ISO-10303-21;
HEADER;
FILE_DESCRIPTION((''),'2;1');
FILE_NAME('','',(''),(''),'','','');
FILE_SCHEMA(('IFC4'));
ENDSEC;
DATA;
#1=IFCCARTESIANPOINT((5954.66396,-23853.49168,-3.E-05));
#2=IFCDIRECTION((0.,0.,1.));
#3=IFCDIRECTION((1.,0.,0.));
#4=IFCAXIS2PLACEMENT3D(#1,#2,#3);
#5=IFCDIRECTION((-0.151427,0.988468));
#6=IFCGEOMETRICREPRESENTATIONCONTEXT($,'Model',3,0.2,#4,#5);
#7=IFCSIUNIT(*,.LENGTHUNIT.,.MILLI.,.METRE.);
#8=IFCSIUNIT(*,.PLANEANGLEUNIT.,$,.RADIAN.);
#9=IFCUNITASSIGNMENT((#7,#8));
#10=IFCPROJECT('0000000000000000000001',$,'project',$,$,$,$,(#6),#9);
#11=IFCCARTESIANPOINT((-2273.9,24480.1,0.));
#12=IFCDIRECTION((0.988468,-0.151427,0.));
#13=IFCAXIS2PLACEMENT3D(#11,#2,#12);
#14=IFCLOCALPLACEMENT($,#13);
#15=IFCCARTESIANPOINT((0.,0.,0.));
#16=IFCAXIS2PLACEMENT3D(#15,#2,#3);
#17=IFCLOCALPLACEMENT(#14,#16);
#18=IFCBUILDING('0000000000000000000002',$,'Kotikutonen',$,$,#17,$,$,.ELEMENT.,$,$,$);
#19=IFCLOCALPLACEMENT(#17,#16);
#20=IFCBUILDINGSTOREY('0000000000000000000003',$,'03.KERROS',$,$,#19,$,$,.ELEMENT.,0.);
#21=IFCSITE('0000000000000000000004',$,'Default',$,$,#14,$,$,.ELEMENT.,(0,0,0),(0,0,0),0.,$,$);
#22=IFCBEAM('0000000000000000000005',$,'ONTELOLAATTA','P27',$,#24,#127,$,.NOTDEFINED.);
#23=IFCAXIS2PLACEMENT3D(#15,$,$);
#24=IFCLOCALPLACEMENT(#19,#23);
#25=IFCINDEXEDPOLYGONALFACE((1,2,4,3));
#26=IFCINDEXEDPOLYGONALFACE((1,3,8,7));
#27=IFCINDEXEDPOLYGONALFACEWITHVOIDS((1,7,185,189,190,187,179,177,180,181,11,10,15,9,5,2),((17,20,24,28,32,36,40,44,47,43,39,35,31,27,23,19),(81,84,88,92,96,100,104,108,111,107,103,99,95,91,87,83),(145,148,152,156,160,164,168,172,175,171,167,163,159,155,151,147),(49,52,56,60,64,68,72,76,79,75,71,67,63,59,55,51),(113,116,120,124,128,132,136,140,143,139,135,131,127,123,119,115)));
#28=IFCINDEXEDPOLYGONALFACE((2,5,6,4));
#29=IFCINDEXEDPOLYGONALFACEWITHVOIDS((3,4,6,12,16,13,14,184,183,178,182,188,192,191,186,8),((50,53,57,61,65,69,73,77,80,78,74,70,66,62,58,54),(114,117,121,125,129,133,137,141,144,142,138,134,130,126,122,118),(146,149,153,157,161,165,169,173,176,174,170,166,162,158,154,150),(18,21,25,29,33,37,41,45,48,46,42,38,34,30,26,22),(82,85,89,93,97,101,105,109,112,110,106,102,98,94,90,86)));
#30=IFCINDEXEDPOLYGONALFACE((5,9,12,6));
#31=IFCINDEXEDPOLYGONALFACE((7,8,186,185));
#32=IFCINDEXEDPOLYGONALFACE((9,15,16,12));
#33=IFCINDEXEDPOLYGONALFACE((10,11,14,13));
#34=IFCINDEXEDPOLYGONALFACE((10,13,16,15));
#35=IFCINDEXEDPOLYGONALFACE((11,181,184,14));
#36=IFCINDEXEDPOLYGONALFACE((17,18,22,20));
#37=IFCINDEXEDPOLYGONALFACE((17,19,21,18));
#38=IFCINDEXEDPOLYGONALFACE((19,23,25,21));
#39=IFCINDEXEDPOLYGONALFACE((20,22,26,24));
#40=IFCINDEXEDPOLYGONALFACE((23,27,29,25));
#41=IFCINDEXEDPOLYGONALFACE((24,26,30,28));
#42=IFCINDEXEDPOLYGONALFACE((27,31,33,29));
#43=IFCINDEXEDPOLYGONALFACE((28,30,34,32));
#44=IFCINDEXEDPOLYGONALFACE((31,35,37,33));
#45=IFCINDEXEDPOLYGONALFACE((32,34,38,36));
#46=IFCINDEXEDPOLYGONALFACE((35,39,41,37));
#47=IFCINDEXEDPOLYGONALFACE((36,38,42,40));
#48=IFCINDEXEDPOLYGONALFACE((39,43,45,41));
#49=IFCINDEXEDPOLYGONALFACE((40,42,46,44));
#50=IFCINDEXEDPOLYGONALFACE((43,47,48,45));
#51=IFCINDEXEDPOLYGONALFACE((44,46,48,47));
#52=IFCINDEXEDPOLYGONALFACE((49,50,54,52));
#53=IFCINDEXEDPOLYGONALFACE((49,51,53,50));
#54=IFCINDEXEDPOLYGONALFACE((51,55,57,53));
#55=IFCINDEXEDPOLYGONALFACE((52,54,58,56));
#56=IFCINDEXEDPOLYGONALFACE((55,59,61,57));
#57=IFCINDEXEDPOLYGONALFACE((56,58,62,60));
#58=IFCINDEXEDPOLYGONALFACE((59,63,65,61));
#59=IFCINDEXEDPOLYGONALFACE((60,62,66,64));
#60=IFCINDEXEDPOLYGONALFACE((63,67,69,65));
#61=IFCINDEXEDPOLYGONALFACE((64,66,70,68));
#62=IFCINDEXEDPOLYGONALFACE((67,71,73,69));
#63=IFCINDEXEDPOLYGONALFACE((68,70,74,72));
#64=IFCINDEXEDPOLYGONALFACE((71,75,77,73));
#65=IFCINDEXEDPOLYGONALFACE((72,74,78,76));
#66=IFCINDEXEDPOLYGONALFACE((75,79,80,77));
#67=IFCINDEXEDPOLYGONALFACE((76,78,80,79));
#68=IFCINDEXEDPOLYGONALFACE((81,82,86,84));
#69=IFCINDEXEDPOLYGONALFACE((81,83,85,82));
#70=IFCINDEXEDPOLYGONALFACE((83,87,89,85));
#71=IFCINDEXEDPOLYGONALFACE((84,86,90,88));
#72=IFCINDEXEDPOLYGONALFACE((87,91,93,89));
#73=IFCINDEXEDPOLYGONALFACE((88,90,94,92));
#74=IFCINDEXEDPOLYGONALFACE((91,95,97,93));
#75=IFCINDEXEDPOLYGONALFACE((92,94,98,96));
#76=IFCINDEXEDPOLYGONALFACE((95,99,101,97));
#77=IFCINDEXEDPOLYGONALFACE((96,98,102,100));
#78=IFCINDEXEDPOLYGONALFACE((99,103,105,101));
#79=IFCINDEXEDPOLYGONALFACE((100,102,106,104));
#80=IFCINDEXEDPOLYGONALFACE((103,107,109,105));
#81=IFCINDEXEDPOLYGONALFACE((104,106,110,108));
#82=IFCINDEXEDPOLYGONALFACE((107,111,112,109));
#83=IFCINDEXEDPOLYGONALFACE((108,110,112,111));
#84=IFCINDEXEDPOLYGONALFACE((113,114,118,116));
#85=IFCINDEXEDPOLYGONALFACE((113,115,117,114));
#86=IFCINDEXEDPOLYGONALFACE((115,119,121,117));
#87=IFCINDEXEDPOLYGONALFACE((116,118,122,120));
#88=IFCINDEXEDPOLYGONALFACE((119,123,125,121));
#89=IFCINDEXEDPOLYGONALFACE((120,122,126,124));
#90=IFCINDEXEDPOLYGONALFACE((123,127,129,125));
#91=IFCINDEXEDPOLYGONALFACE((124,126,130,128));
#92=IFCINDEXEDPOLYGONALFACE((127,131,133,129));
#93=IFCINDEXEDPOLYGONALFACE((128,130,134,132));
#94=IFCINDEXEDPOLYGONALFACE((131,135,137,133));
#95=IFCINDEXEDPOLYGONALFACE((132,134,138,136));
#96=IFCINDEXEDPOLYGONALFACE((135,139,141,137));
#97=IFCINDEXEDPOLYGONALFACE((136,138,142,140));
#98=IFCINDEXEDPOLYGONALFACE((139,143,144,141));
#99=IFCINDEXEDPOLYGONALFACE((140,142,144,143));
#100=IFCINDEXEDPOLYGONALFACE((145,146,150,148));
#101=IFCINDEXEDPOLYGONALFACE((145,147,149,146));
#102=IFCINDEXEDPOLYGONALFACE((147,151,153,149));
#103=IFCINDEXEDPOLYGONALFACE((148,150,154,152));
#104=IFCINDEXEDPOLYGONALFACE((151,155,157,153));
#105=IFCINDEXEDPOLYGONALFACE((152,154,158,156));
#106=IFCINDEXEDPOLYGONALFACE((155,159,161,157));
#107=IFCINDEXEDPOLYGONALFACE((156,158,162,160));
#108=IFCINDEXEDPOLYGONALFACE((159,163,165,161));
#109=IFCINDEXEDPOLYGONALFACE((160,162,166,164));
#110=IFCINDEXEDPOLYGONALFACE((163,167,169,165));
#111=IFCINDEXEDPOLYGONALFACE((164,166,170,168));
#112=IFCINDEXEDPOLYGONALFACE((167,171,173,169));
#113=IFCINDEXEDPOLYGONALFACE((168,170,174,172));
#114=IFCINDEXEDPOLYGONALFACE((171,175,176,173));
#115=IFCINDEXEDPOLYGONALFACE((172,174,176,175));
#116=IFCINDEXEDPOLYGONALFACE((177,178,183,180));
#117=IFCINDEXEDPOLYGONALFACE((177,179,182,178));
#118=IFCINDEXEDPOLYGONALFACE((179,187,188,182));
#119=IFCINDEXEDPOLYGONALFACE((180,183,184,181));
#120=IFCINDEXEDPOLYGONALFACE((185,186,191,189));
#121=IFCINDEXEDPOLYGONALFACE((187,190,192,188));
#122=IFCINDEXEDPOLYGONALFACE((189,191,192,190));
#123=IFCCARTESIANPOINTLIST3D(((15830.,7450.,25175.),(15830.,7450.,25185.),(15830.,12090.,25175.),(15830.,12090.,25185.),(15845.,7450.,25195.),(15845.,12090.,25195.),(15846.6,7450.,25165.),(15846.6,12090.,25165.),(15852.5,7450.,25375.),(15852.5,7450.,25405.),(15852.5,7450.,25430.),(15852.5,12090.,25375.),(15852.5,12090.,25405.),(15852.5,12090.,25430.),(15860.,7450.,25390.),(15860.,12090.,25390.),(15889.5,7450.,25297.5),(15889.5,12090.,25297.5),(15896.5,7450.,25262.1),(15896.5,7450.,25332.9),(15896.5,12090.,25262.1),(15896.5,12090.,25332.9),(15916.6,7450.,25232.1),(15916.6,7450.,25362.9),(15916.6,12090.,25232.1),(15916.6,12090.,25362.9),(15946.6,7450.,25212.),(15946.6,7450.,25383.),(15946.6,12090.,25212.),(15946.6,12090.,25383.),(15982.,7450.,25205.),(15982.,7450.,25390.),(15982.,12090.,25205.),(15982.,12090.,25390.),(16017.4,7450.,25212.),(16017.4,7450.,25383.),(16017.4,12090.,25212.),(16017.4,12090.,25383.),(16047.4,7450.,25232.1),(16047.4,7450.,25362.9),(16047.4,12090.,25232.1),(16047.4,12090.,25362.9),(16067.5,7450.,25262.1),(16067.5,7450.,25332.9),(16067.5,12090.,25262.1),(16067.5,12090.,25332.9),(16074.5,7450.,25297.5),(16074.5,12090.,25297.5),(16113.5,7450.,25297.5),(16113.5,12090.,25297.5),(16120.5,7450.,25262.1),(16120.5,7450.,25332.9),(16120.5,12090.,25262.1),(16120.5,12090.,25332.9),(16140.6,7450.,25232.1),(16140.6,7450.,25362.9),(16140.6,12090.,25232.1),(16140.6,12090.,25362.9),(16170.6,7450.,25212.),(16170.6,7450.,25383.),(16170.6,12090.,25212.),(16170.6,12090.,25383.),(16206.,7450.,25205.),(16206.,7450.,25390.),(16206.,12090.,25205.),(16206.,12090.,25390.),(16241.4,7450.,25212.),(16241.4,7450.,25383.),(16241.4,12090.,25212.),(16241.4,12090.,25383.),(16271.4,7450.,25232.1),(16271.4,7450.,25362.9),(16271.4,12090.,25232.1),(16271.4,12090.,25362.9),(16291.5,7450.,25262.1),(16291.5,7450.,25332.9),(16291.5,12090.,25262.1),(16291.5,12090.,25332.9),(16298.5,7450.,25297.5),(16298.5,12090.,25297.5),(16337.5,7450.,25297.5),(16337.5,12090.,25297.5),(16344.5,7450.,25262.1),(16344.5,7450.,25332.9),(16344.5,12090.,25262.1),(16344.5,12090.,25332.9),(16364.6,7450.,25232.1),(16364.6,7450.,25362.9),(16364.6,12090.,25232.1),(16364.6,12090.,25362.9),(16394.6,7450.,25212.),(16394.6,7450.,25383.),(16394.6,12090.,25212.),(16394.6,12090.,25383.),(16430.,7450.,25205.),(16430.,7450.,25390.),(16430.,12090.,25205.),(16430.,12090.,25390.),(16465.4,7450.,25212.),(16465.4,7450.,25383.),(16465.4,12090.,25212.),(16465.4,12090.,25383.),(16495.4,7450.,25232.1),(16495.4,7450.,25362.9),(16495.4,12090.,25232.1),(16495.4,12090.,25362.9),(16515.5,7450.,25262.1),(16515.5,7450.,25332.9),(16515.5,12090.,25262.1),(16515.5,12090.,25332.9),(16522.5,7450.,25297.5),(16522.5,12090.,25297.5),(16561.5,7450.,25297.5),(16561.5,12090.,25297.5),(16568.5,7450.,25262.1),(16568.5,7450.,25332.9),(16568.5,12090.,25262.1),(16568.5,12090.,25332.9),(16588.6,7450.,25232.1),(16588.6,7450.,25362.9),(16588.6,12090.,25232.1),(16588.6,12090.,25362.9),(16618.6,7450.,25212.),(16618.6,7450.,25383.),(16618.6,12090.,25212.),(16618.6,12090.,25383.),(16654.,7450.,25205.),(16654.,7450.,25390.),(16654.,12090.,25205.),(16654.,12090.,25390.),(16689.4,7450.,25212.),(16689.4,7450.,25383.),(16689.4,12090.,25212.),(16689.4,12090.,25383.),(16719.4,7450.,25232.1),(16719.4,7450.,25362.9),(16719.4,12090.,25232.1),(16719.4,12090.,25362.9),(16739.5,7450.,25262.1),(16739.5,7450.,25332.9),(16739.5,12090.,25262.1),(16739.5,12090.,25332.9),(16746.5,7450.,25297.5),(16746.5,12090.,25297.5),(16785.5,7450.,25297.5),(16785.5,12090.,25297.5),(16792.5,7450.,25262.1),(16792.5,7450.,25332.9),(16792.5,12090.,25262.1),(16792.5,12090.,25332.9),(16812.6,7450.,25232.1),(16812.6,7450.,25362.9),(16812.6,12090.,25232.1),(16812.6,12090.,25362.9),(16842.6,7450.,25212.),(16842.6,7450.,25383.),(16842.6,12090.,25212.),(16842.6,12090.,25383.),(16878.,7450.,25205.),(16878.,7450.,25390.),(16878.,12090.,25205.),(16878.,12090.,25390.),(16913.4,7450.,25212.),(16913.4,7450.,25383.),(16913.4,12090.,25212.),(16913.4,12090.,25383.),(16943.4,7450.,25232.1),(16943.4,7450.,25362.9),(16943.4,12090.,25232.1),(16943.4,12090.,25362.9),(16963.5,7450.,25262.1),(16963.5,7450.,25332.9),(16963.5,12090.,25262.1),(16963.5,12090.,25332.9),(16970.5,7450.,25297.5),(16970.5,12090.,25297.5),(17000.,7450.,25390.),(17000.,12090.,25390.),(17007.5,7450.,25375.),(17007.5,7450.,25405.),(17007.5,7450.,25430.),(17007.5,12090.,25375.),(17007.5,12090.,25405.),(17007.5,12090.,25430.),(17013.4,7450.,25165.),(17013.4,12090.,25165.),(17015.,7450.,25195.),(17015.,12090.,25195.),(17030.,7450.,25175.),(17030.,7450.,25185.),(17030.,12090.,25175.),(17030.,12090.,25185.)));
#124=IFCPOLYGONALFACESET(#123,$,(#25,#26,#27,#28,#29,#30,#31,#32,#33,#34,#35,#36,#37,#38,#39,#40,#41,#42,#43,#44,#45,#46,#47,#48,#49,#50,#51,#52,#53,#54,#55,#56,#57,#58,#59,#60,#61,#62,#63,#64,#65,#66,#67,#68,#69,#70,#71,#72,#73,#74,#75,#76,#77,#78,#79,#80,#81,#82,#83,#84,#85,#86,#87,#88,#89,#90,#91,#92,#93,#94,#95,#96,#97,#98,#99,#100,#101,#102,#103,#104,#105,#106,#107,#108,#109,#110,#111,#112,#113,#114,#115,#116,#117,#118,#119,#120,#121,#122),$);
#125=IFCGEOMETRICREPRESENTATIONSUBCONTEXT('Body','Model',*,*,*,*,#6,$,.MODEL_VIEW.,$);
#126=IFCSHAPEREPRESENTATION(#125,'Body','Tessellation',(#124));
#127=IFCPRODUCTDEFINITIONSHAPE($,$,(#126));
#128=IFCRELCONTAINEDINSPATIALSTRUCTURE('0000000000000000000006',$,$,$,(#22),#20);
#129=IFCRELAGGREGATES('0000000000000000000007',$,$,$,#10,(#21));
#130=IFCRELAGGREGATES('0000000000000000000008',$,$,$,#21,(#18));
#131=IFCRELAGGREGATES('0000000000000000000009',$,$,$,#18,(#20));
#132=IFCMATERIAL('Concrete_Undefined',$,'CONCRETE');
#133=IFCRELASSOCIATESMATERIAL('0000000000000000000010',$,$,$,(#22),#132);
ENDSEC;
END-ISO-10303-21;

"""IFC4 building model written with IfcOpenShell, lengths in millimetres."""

from ifc_helpers import new_model, si_unit, direction, frame, origin_with_axes, place, context, subcontext, project, spatial, line, indexed_curve, outline, extrude, material, element, save


model = new_model("IFC4")

# Units and contexts
model_context = context("Model", 3, precision=0.2, world=frame((5954.66396, -23853.49168, -3e-05), z_axis=(0.0, 0.0, 1.0), x_axis=(1.0, 0.0, 0.0)), true_north=direction((-0.151427, 0.988468)))
body_context = subcontext(model_context, "Body", "Model", "MODEL_VIEW")
ifc_project = project(units=[si_unit("LENGTHUNIT", "METRE", prefix="MILLI"), si_unit("PLANEANGLEUNIT", "RADIAN")], contexts=[model_context])

# Site, building, storey
site_placement = place(None, frame((-2273.9, 24480.1, 0.0), z_axis=(0.0, 0.0, 1.0), x_axis=(0.988468, -0.151427, 0.0)))
site = spatial("IfcSite", under=ifc_project, at=site_placement, Name="Default", CompositionType="ELEMENT", RefLatitude=(0, 0, 0), RefLongitude=(0, 0, 0), RefElevation=0.0)
building_placement = place(site_placement, origin_with_axes())
building = spatial("IfcBuilding", under=site, at=building_placement, Name="Kotikutonen", CompositionType="ELEMENT")
storey_placement = place(building_placement, origin_with_axes())
storey = spatial("IfcBuildingStorey", under=building, at=storey_placement, Name="03.KERROS", CompositionType="ELEMENT", Elevation=0.0)

# Shared definitions
ifc_material_1 = material(Name="Concrete_Undefined", Category="CONCRETE")

# Beam
beam_1_placement = place(storey_placement, frame((16430.0, 12090.0, 25297.5), z_axis=(-1.0, 0.0, 0.0), x_axis=(0.0, -1.0, 0.0)))
element("IfcBeam", 1, at=beam_1_placement, inside=storey, material=ifc_material_1, Name="ONTELOLAATTA", Description="P27", PredefinedType="NOTDEFINED", context=body_context, shape_type="SolidModel", body=[
    extrude(outline(indexed_curve([(-600.0, -122.5), (-583.4, -132.5), (583.4, -132.5), (600.0, -122.5), (600.0, -112.5), (585.0, -102.5), (577.5, 77.5), (570.0, 92.5), (577.5, 107.5), (577.5, 132.5), (-577.5, 132.5), (-577.5, 107.5), (-570.0, 92.5), (-577.5, 77.5), (-585.0, -102.5), (-600.0, -112.5)], segments=[line(1, 2, 3, 4, 5, 6, 7, 8, 9, 10, 11, 12, 13, 14, 15, 16, 1)]), holes=[indexed_curve([(-448.0, -92.5), (-483.4, -85.5), (-513.4, -65.4), (-533.5, -35.4), (-540.5, 0.0), (-533.5, 35.4), (-513.4, 65.4), (-483.4, 85.5), (-448.0, 92.5), (-412.6, 85.5), (-382.6, 65.4), (-362.5, 35.4), (-355.5, 0.0), (-362.5, -35.4), (-382.6, -65.4), (-412.6, -85.5)], segments=[line(1, 2, 3, 4, 5, 6, 7, 8, 9, 10, 11, 12, 13, 14, 15, 16, 1)]), indexed_curve([(-224.0, -92.5), (-259.4, -85.5), (-289.4, -65.4), (-309.5, -35.4), (-316.5, 0.0), (-309.5, 35.4), (-289.4, 65.4), (-259.4, 85.5), (-224.0, 92.5), (-188.6, 85.5), (-158.6, 65.4), (-138.5, 35.4), (-131.5, 0.0), (-138.5, -35.4), (-158.6, -65.4), (-188.6, -85.5)], segments=[line(1, 2, 3, 4, 5, 6, 7, 8, 9, 10, 11, 12, 13, 14, 15, 16, 1)]), indexed_curve([(0.0, -92.5), (-35.4, -85.5), (-65.4, -65.4), (-85.5, -35.4), (-92.5, 0.0), (-85.5, 35.4), (-65.4, 65.4), (-35.4, 85.5), (0.0, 92.5), (35.4, 85.5), (65.4, 65.4), (85.5, 35.4), (92.5, 0.0), (85.5, -35.4), (65.4, -65.4), (35.4, -85.5)], segments=[line(1, 2, 3, 4, 5, 6, 7, 8, 9, 10, 11, 12, 13, 14, 15, 16, 1)]), indexed_curve([(224.0, -92.5), (188.6, -85.5), (158.6, -65.4), (138.5, -35.4), (131.5, 0.0), (138.5, 35.4), (158.6, 65.4), (188.6, 85.5), (224.0, 92.5), (259.4, 85.5), (289.4, 65.4), (309.5, 35.4), (316.5, 0.0), (309.5, -35.4), (289.4, -65.4), (259.4, -85.5)], segments=[line(1, 2, 3, 4, 5, 6, 7, 8, 9, 10, 11, 12, 13, 14, 15, 16, 1)]), indexed_curve([(448.0, -92.5), (412.6, -85.5), (382.6, -65.4), (362.5, -35.4), (355.5, 0.0), (362.5, 35.4), (382.6, 65.4), (412.6, 85.5), (448.0, 92.5), (483.4, 85.5), (513.4, 65.4), (533.5, 35.4), (540.5, 0.0), (533.5, -35.4), (513.4, -65.4), (483.4, -85.5)], segments=[line(1, 2, 3, 4, 5, 6, 7, 8, 9, 10, 11, 12, 13, 14, 15, 16, 1)])]), frame((0.0, 0.0, 0.0), z_axis=(-1.0, 0.0, 0.0), x_axis=(0.0, 0.0, 1.0)), (0.0, 0.0, -1.0), 4640.0),
])

save(model, "model.ifc")
